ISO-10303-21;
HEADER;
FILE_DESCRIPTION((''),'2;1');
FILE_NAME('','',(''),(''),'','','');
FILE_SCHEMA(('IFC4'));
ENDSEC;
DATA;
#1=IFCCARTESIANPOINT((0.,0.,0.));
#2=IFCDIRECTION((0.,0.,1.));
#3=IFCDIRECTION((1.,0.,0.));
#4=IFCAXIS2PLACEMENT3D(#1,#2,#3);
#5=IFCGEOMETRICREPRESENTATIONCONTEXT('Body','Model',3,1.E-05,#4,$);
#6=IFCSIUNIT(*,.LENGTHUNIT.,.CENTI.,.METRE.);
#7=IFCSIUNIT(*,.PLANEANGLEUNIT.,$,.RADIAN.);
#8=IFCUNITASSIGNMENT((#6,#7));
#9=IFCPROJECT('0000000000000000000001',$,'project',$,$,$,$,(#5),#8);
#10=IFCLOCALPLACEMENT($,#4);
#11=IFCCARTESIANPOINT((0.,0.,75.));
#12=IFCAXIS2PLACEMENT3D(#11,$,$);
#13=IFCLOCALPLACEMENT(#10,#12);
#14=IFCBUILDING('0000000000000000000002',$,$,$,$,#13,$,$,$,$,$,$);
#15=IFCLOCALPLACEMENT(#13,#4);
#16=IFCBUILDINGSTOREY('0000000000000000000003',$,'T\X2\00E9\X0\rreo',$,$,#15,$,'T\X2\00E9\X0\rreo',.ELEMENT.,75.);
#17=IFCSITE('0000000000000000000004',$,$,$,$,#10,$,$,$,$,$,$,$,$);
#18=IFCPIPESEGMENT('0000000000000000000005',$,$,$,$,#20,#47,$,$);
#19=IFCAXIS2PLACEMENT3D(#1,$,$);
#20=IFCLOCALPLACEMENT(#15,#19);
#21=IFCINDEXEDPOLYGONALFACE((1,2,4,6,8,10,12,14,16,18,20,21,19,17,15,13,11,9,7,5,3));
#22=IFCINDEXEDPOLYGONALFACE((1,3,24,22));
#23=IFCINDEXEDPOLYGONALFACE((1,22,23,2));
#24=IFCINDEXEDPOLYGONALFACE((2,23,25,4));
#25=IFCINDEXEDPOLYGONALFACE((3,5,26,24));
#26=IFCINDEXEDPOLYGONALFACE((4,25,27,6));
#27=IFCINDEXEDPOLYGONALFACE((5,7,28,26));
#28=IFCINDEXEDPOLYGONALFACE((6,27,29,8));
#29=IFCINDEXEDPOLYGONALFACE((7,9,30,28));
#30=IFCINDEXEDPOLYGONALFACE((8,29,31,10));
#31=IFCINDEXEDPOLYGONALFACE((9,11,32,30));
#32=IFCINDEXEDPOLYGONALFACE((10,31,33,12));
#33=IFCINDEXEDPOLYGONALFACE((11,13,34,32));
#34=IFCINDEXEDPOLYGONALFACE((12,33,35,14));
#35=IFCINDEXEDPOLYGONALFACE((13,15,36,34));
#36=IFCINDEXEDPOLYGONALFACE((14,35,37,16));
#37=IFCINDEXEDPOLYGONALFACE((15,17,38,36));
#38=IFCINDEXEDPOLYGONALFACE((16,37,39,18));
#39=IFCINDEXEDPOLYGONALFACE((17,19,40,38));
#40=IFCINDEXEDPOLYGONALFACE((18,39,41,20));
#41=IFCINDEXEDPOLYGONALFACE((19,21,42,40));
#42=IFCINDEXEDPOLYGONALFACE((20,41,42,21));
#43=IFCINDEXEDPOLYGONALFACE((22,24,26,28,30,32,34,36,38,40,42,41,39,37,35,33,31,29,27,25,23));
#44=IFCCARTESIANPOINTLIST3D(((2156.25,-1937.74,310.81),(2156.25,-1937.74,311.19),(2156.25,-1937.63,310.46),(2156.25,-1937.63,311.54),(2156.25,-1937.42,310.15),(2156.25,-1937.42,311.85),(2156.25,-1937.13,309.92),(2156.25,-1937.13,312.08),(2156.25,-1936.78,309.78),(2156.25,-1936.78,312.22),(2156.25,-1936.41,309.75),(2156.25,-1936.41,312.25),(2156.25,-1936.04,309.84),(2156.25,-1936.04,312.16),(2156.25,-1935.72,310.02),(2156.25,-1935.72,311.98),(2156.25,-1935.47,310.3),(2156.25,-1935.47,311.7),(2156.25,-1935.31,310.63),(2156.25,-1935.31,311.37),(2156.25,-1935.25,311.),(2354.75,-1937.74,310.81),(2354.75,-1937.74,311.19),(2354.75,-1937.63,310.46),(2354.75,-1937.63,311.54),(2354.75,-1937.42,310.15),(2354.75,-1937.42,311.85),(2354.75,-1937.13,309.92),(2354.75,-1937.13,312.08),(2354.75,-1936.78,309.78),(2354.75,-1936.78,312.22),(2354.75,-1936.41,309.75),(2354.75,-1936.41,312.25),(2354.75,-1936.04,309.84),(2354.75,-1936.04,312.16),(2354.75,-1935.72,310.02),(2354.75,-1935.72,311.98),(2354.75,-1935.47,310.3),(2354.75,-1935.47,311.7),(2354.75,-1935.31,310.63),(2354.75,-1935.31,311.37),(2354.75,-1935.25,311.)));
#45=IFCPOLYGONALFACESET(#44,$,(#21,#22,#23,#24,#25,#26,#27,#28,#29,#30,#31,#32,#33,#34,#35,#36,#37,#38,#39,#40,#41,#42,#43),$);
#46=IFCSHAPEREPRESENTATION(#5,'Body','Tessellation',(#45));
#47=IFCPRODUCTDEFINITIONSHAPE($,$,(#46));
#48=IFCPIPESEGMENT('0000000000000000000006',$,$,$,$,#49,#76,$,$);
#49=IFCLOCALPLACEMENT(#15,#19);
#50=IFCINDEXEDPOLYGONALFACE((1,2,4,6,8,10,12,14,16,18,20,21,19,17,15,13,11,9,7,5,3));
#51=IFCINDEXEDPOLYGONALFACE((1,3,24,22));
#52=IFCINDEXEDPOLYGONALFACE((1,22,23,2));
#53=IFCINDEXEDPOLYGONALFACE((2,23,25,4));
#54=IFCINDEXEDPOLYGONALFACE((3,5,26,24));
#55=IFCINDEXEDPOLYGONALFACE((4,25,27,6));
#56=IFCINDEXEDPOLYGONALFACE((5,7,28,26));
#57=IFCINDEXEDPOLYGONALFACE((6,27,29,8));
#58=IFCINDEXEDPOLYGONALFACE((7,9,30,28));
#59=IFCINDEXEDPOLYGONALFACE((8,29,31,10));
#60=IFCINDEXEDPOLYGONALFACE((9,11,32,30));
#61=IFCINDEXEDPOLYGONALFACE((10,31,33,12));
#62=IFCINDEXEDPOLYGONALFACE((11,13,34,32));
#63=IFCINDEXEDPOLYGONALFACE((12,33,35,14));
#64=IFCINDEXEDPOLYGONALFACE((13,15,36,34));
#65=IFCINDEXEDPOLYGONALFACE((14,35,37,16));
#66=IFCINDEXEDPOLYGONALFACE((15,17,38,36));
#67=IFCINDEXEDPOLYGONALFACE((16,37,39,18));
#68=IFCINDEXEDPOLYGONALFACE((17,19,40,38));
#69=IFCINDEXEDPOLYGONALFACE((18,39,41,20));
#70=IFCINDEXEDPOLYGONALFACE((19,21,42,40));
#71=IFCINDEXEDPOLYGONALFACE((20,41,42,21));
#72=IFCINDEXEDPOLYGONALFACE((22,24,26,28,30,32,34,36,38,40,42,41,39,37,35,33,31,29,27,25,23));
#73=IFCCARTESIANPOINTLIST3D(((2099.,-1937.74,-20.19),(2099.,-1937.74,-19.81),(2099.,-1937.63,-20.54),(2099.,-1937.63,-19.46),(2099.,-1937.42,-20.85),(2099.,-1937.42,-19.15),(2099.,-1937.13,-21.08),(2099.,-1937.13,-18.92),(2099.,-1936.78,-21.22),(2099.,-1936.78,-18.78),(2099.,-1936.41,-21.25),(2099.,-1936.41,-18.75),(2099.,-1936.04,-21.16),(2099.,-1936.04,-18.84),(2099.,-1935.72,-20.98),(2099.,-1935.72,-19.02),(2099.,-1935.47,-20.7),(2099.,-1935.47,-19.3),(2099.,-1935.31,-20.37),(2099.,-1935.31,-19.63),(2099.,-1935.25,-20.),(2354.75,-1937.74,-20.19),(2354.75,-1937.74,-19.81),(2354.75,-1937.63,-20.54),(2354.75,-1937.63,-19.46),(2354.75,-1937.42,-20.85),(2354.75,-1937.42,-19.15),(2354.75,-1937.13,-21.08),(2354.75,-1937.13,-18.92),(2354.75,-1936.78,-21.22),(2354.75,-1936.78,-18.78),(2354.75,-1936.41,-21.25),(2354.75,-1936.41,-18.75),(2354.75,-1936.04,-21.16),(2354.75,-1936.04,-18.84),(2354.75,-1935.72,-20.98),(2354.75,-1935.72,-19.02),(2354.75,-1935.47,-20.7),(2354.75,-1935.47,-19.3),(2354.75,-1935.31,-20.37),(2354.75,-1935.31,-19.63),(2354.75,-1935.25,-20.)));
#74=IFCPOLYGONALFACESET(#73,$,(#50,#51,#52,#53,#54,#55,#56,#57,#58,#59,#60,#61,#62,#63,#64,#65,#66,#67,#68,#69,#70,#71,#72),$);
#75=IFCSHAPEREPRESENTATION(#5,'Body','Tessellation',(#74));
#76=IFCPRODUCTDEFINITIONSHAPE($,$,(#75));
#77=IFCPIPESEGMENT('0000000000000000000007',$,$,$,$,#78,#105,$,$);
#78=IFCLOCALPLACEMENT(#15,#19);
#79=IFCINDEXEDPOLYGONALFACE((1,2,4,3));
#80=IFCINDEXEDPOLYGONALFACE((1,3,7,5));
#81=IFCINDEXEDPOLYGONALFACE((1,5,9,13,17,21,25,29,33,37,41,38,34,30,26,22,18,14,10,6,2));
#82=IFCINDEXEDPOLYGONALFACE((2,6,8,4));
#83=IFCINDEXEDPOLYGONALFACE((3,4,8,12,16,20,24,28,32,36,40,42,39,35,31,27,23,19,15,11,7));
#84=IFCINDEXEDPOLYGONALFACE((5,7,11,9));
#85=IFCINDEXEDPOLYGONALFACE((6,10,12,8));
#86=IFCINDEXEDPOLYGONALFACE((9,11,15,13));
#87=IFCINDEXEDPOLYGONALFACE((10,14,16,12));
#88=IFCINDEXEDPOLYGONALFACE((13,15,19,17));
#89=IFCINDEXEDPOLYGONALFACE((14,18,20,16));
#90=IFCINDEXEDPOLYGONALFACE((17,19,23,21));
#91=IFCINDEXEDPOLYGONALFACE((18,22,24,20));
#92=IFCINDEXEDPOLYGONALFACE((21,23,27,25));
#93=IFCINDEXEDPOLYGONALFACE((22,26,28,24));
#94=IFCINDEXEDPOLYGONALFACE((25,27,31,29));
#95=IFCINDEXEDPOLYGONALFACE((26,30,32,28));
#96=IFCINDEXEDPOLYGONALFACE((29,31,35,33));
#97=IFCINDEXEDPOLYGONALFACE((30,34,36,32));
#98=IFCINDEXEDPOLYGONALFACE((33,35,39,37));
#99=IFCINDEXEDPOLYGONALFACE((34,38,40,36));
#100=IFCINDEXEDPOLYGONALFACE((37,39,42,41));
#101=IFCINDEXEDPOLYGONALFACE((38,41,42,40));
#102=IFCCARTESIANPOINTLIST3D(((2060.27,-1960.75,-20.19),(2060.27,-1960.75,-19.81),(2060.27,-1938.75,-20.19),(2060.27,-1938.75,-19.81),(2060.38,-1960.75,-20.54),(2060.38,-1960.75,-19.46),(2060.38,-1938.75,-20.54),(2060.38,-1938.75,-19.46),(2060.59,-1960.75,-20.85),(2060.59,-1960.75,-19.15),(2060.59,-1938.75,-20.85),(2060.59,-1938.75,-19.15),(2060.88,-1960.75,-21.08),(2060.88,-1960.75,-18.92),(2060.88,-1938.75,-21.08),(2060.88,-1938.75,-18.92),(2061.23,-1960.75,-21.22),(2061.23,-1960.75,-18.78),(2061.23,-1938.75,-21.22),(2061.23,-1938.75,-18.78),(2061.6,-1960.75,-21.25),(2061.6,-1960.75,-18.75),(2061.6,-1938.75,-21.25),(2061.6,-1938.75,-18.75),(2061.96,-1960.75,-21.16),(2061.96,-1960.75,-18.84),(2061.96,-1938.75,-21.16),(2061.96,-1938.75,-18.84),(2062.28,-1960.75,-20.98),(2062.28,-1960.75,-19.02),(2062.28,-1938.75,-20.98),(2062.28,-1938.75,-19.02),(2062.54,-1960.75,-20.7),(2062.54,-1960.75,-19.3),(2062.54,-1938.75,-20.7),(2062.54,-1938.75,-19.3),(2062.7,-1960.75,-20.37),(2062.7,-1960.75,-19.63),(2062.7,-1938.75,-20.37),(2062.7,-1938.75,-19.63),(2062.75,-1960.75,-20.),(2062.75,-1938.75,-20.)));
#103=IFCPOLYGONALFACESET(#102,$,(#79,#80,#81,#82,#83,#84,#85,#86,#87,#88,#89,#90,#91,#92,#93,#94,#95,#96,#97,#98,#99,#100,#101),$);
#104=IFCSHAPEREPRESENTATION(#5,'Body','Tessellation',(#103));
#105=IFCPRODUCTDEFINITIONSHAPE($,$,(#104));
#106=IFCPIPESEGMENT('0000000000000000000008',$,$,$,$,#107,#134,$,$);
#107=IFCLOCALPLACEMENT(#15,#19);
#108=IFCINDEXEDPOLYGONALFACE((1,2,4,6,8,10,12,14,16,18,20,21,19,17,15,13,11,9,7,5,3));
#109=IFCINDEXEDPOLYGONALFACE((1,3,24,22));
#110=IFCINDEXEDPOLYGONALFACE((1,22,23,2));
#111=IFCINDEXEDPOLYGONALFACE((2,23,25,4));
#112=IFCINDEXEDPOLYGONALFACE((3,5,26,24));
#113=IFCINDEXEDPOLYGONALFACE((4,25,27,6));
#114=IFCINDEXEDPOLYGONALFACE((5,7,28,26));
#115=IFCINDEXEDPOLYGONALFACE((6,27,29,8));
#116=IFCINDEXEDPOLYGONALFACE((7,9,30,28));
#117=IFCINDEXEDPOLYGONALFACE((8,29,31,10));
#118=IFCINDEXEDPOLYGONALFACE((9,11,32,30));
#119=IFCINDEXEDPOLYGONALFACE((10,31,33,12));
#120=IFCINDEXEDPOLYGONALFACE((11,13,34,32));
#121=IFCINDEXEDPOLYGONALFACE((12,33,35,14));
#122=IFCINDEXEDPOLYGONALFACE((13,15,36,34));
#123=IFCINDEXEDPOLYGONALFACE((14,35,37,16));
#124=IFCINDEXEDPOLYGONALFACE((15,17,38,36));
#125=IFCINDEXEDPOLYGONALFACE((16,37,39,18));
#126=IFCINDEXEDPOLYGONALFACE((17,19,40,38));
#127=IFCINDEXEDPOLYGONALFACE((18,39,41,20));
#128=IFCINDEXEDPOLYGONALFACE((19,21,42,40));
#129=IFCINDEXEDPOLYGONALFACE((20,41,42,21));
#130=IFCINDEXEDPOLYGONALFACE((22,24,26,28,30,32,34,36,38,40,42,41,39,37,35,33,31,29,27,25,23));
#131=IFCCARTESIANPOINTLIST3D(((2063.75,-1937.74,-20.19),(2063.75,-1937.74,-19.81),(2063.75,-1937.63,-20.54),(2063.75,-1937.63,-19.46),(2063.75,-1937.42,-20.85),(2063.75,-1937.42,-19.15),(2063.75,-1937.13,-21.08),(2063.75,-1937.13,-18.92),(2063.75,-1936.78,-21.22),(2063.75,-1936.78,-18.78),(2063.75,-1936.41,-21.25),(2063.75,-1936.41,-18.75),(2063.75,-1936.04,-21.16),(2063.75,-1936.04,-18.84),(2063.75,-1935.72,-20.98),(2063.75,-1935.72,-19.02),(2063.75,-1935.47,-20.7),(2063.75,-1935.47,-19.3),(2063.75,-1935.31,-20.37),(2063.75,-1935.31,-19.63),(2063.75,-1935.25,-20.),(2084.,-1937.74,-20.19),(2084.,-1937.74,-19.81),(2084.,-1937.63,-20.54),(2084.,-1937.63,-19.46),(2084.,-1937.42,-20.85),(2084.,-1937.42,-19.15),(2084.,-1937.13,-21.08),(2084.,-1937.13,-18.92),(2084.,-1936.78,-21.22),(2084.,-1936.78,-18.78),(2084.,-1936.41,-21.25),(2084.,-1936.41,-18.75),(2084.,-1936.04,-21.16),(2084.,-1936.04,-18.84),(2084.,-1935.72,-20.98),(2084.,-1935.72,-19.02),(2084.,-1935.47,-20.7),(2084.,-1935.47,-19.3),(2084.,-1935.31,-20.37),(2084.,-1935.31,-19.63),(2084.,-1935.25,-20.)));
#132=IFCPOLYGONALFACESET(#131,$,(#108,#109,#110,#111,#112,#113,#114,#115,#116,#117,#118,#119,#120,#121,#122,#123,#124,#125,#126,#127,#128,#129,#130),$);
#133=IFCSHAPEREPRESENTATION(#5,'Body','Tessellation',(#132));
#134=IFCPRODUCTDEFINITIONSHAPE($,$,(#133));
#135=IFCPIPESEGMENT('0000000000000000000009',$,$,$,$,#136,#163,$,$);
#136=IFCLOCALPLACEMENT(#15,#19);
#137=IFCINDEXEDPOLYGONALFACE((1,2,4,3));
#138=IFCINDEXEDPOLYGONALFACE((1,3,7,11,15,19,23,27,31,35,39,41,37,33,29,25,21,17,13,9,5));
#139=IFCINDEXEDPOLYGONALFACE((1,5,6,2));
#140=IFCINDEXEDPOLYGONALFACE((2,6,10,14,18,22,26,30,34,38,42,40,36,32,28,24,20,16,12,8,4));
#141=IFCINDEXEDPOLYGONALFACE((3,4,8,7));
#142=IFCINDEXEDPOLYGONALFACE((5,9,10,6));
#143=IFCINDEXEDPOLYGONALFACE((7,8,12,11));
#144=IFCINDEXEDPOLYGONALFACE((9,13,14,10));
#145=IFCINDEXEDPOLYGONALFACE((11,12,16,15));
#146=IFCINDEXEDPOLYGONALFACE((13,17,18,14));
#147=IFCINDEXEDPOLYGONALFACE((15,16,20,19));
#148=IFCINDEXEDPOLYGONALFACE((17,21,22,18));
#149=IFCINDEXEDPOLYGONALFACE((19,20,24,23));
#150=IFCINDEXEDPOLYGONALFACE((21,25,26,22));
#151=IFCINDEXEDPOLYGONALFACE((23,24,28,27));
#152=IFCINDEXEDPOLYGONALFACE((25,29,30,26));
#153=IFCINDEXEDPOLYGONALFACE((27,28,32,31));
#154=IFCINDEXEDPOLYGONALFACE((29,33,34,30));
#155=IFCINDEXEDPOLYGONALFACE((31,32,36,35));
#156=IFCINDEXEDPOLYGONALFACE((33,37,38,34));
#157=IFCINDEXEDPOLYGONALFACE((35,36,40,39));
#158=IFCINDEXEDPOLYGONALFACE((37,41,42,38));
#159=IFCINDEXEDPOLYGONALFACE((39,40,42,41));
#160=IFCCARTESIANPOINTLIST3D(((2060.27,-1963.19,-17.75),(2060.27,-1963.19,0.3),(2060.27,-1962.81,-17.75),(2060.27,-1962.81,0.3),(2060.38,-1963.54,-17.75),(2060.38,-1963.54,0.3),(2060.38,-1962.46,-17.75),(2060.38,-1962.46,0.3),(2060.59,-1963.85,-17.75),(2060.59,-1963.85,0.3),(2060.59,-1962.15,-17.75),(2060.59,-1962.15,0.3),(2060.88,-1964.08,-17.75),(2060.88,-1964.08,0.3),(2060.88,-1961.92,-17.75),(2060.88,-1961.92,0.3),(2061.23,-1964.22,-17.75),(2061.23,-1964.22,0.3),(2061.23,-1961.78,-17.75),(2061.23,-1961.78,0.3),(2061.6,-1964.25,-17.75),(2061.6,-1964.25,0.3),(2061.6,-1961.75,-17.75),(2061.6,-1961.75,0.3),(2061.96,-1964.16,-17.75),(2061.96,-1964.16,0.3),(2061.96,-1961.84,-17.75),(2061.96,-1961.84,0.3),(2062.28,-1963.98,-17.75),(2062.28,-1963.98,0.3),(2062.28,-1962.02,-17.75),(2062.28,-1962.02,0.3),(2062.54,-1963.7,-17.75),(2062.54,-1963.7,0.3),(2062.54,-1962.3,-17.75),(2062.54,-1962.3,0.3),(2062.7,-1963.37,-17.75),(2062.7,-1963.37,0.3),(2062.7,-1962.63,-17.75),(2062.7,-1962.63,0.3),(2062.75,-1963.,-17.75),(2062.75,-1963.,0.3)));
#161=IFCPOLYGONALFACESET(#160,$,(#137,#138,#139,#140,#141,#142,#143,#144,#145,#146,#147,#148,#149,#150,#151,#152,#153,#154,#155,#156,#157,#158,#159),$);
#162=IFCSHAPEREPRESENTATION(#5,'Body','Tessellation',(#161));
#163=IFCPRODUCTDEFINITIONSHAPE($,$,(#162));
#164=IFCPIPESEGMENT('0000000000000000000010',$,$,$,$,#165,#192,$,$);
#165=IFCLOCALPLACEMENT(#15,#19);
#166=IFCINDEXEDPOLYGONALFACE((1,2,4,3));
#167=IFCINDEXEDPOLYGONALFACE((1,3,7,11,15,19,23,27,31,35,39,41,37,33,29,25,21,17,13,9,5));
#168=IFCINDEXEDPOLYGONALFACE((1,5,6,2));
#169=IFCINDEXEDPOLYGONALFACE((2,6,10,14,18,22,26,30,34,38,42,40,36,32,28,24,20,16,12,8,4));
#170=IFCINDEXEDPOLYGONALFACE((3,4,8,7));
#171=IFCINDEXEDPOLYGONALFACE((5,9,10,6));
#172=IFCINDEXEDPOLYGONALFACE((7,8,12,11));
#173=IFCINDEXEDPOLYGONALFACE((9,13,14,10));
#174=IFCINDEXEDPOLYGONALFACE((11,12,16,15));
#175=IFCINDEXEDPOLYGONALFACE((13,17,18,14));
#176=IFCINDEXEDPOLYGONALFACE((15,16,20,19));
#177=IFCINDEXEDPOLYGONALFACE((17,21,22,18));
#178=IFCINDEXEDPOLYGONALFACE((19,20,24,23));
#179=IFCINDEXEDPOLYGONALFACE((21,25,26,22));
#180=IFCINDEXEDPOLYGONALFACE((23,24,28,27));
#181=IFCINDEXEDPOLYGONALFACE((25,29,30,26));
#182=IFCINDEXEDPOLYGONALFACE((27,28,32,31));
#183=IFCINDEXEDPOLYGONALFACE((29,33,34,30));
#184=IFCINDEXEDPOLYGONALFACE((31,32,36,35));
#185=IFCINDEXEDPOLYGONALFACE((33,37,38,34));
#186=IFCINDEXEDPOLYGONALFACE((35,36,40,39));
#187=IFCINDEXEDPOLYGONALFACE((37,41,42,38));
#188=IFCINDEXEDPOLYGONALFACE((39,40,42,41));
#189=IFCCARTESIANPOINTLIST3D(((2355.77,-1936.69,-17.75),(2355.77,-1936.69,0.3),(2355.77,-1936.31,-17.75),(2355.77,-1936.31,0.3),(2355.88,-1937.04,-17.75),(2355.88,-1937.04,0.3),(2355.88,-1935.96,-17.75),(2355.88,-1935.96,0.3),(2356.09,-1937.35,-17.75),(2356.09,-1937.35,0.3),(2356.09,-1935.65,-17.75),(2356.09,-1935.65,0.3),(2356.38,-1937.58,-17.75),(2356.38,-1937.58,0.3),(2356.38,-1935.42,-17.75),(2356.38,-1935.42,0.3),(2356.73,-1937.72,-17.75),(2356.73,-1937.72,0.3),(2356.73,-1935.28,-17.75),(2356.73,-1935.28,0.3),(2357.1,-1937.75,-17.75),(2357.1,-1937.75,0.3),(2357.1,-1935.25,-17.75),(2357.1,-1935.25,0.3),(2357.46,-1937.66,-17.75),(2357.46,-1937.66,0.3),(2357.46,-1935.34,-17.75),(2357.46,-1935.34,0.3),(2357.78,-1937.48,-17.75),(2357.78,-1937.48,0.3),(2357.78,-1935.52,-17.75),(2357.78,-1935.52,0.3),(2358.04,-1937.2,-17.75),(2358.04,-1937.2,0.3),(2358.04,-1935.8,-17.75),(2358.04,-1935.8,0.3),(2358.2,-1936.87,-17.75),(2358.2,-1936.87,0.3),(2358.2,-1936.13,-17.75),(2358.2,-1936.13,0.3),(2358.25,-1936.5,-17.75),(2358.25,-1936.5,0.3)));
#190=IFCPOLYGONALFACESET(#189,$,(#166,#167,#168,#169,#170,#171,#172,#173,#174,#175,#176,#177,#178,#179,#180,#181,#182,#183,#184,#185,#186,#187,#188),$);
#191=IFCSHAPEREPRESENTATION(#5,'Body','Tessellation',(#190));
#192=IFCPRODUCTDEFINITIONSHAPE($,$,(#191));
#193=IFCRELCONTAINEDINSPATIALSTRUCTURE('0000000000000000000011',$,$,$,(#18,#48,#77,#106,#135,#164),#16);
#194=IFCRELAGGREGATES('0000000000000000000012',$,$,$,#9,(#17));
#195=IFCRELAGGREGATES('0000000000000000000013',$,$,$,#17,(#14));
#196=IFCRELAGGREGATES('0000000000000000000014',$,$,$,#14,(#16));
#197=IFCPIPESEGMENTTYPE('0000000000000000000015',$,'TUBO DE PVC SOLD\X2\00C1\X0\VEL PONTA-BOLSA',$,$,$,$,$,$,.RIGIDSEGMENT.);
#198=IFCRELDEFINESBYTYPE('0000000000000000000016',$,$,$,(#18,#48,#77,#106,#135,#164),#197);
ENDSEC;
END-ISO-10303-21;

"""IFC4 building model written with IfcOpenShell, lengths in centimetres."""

from ifc_helpers import new_model, si_unit, frame, origin_with_axes, origin_2d_with_axis, place, context, project, spatial, circle, extrude, type_object, element, save


model = new_model("IFC4")

# Units and contexts
model_context = context("Model", 3, precision=1e-05, world=origin_with_axes(), identifier="Body")
ifc_project = project(units=[si_unit("LENGTHUNIT", "METRE", prefix="CENTI"), si_unit("PLANEANGLEUNIT", "RADIAN")], contexts=[model_context])

# Site, building, storey
site_placement = place(None, origin_with_axes())
site = spatial("IfcSite", under=ifc_project, at=site_placement)
building_placement = place(site_placement, frame((0.0, 0.0, 75.0)))
building = spatial("IfcBuilding", under=site, at=building_placement)
storey_placement = place(building_placement, origin_with_axes())
storey = spatial("IfcBuildingStorey", under=building, at=storey_placement, Name="Térreo", LongName="Térreo", CompositionType="ELEMENT", Elevation=75.0)

# Pipe segments
pipe_segment_type_1 = type_object("IfcPipeSegmentType", Name="TUBO DE PVC SOLDÁVEL PONTA-BOLSA", PredefinedType="RIGIDSEGMENT")
pipe_segment_1_placement = place(storey_placement, frame((2255.5, -1936.5, 312.25), z_axis=(0.0, 0.0, 1.0), x_axis=(1.0, 0.0, 0.0)))
element("IfcPipeSegment", 1, at=pipe_segment_1_placement, inside=storey, type_object=pipe_segment_type_1, context=model_context, shape_type="SolidModel", body=[
    extrude(circle(Radius=1.25, at=origin_2d_with_axis()), frame((-99.25, 0.0, -1.25), z_axis=(1.0, 0.0, 0.0), x_axis=(0.0, 1.0, 0.0)), (0.0, 0.0, 1.0), 198.5),
])
pipe_segment_2_placement = place(storey_placement, frame((2226.88, -1936.5, -18.75), z_axis=(0.0, 0.0, 1.0), x_axis=(1.0, 0.0, 0.0)))
element("IfcPipeSegment", 2, at=pipe_segment_2_placement, inside=storey, type_object=pipe_segment_type_1, context=model_context, shape_type="SolidModel", body=[
    extrude(circle(Radius=1.25, at=origin_2d_with_axis()), frame((127.88, 0.0, -1.25), z_axis=(-1.0, 0.0, 0.0), x_axis=(0.0, 1.0, 0.0)), (0.0, 0.0, 1.0), 255.75),
])
pipe_segment_3_placement = place(storey_placement, frame((2061.5, -1949.75, -18.75), z_axis=(0.0, 0.0, 1.0), x_axis=(1.0, 0.0, 0.0)))
element("IfcPipeSegment", 3, at=pipe_segment_3_placement, inside=storey, type_object=pipe_segment_type_1, context=model_context, shape_type="SolidModel", body=[
    extrude(circle(Radius=1.25, at=origin_2d_with_axis()), frame((0.0, 11.0, -1.25), z_axis=(0.0, -1.0, 0.0), x_axis=(1.0, 0.0, 0.0)), (0.0, 0.0, 1.0), 22.0),
])
pipe_segment_4_placement = place(storey_placement, frame((2073.88, -1936.5, -18.75), z_axis=(0.0, 0.0, 1.0), x_axis=(1.0, 0.0, 0.0)))
element("IfcPipeSegment", 4, at=pipe_segment_4_placement, inside=storey, type_object=pipe_segment_type_1, context=model_context, shape_type="SolidModel", body=[
    extrude(circle(Radius=1.25, at=origin_2d_with_axis()), frame((10.12, 0.0, -1.25), z_axis=(-1.0, 0.0, 0.0), x_axis=(0.0, 1.0, 0.0)), (0.0, 0.0, 1.0), 20.25),
])
pipe_segment_5_placement = place(storey_placement, frame((2061.5, -1963.0, 0.3), z_axis=(0.0, 0.0, 1.0), x_axis=(1.0, 0.0, 0.0)))
element("IfcPipeSegment", 5, at=pipe_segment_5_placement, inside=storey, type_object=pipe_segment_type_1, context=model_context, shape_type="SolidModel", body=[
    extrude(circle(Radius=1.25, at=origin_2d_with_axis()), frame((0.0, 0.0, -18.05), z_axis=(0.0, 0.0, 1.0), x_axis=(1.0, 0.0, 0.0)), (0.0, 0.0, 1.0), 18.05),
])
pipe_segment_6_placement = place(storey_placement, frame((2357.0, -1936.5, 0.3), z_axis=(0.0, 0.0, 1.0), x_axis=(1.0, 0.0, 0.0)))
element("IfcPipeSegment", 6, at=pipe_segment_6_placement, inside=storey, type_object=pipe_segment_type_1, context=model_context, shape_type="SolidModel", body=[
    extrude(circle(Radius=1.25, at=origin_2d_with_axis()), frame((0.0, 0.0, 0.0), z_axis=(0.0, 0.0, -1.0), x_axis=(1.0, 0.0, 0.0)), (0.0, 0.0, 1.0), 18.05),
])

save(model, "model.ifc")
